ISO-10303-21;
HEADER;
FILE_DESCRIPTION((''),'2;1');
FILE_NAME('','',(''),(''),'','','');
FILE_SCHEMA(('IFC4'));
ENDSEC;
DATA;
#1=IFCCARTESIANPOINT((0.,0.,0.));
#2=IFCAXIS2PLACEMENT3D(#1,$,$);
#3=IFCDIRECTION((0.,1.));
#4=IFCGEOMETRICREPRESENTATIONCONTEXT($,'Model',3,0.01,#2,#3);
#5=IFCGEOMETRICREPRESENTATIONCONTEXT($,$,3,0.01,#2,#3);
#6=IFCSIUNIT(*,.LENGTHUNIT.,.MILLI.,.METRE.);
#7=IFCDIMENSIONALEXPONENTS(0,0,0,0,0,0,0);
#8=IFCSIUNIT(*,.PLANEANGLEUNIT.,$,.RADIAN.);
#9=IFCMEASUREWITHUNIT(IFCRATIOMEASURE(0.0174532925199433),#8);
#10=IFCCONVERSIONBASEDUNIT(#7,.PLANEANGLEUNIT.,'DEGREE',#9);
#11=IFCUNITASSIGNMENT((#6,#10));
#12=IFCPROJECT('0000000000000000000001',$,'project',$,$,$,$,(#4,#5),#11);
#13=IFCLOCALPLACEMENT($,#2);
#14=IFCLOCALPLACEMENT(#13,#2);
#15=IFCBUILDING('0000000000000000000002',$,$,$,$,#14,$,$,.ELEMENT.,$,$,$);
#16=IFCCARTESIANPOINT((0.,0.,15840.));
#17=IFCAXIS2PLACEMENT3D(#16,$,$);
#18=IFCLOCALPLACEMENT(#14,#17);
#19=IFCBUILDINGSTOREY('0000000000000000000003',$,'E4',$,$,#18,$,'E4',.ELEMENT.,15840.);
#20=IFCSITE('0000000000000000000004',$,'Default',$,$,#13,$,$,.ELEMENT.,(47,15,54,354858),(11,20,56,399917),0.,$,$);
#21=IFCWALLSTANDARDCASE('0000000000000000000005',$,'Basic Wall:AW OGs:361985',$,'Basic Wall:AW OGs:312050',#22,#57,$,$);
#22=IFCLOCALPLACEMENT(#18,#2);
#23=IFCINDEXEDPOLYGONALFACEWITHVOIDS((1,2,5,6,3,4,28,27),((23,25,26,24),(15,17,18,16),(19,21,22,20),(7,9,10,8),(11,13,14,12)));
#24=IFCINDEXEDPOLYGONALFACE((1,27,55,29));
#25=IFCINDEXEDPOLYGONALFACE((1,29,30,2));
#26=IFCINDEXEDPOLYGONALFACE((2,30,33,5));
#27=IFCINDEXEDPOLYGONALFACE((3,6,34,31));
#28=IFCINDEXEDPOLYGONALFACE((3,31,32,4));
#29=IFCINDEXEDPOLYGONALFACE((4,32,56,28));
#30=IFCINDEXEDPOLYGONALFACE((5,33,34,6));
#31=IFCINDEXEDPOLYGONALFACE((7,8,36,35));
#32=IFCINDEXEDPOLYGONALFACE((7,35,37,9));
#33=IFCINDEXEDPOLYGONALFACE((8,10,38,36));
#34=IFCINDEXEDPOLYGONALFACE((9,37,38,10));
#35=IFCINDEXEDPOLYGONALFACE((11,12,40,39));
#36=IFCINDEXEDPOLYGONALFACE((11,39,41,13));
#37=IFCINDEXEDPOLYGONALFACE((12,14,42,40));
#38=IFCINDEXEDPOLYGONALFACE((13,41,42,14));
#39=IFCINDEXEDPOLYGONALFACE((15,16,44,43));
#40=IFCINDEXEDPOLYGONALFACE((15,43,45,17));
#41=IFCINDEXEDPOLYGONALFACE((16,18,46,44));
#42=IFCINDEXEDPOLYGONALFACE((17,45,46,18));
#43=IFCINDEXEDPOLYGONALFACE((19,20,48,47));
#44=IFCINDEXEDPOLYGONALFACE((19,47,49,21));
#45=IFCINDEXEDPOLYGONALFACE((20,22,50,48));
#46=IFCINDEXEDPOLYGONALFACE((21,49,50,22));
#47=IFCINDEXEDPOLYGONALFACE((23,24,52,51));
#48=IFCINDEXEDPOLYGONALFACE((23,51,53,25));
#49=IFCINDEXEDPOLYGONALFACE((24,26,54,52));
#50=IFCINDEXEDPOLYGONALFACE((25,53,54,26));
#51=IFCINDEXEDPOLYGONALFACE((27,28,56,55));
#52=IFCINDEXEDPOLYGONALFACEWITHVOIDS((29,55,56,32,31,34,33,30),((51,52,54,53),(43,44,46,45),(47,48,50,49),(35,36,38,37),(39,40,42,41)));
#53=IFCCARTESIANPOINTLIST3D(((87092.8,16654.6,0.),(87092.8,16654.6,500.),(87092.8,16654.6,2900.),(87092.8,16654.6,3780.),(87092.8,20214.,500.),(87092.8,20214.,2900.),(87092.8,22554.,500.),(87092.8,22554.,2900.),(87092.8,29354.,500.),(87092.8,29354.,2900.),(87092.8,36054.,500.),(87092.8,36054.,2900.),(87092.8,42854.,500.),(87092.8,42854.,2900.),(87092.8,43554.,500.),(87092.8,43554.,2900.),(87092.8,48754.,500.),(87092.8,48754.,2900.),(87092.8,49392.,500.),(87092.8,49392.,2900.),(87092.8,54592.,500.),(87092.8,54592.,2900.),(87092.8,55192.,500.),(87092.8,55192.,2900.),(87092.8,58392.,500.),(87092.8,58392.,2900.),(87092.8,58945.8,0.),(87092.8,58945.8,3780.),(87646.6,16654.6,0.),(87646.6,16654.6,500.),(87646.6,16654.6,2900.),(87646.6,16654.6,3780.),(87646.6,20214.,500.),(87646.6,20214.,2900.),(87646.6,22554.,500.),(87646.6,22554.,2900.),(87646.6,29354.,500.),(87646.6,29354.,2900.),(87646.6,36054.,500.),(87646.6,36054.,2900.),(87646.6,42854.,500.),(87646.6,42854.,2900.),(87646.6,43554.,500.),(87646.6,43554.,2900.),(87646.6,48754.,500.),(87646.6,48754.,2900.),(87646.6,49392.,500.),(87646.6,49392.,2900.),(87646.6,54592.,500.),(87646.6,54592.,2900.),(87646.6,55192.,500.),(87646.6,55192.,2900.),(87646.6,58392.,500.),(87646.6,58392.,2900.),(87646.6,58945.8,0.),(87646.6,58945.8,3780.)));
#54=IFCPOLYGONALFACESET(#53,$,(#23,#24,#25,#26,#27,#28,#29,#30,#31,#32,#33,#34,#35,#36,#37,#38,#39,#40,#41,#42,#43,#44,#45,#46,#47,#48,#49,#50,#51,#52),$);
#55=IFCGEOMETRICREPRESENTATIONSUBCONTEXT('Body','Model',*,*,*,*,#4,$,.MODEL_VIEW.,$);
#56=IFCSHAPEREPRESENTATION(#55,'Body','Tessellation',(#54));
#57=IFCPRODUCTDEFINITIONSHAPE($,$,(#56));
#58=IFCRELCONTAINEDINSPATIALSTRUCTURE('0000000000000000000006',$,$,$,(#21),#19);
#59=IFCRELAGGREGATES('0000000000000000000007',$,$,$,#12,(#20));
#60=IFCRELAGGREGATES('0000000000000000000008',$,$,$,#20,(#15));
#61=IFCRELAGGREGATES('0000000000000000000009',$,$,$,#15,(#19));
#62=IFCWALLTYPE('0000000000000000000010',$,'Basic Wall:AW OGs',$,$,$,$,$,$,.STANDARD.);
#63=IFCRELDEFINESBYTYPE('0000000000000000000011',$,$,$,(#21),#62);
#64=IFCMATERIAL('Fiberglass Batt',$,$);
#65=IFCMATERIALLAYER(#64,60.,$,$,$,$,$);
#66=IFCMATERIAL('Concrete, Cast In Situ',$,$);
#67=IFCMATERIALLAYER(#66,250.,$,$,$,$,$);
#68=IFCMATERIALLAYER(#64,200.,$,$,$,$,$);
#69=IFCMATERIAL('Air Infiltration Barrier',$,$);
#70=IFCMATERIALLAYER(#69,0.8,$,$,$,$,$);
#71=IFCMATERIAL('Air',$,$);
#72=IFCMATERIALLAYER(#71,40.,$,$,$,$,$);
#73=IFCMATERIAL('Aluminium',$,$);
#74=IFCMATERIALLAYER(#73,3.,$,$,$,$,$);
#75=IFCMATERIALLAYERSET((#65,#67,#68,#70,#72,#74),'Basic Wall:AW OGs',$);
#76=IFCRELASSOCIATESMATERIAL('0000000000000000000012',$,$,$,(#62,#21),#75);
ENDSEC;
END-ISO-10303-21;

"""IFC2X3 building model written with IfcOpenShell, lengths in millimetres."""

from ifc_helpers import new_model, entity, si_unit, converted_unit, direction, frame, frame_2d, origin, place, context, subcontext, project, spatial, rectangle, extrude, material, layer, layer_set, layer_usage, type_object, element, save


model = new_model("IFC2X3")

# Units and contexts
model_context = context("Model", 3, precision=0.01, world=origin(), true_north=direction((0.0, 1.0)))
context_of_model = context(None, 3, precision=0.01, world=origin(), true_north=direction((0.0, 1.0)))
body_context = subcontext(model_context, "Body", "Model", "MODEL_VIEW")
ifc_project = project(units=[si_unit("LENGTHUNIT", "METRE", prefix="MILLI"), converted_unit("PLANEANGLEUNIT", "DEGREE", entity("IfcRatioMeasure", 0.0174532925199433), si_unit("PLANEANGLEUNIT", "RADIAN"), dimensions=[0, 0, 0, 0, 0, 0, 0])], contexts=[model_context, context_of_model])

# Site, building, storey
site_placement = place(None, origin())
site = spatial("IfcSite", under=ifc_project, at=site_placement, Name="Default", CompositionType="ELEMENT", RefLatitude=(47, 15, 54, 354858), RefLongitude=(11, 20, 56, 399917), RefElevation=0.0)
building_placement = place(site_placement, origin())
building = spatial("IfcBuilding", under=site, at=building_placement, CompositionType="ELEMENT")
storey_placement = place(building_placement, frame((0.0, 0.0, 15840.0)))
storey = spatial("IfcBuildingStorey", under=building, at=storey_placement, Name="E4", LongName="E4", CompositionType="ELEMENT", Elevation=15840.0)

# Shared definitions
ifc_material_1 = material(Name="Concrete, Cast In Situ")

# Shared definitions
ifc_material_2 = material(Name="Fiberglass Batt")
ifc_layer_1 = layer(ifc_material_2, 60.0)
ifc_layer_2 = layer(ifc_material_1, 250.0)
ifc_layer_3 = layer(ifc_material_2, 200.0)
ifc_material_3 = material(Name="Air Infiltration Barrier")
ifc_layer_4 = layer(ifc_material_3, 0.8)
ifc_material_4 = material(Name="Air")
ifc_layer_5 = layer(ifc_material_4, 40.0)
ifc_material_5 = material(Name="Aluminium")
ifc_layer_6 = layer(ifc_material_5, 3.0)
ifc_layer_set_1 = layer_set([ifc_layer_1, ifc_layer_2, ifc_layer_3, ifc_layer_4, ifc_layer_5, ifc_layer_6], Name="Basic Wall:AW OGs")
wall_type_1 = type_object("IfcWallType", Name="Basic Wall:AW OGs", PredefinedType="STANDARD", material=ifc_layer_set_1)

# Wall, openings
ifc_layer_usage_1 = layer_usage(ifc_layer_set_1, "AXIS2", "NEGATIVE", 276.9)
wall_1_placement = place(storey_placement, frame((87369.7, 16654.6, 0.0), z_axis=(0.0, 0.0, 1.0), x_axis=(0.0, 1.0, 0.0)))
wall_1 = element("IfcWallStandardCase", 1, at=wall_1_placement, inside=storey, type_object=wall_type_1, material=ifc_layer_usage_1, Name="Basic Wall:AW OGs:361985", ObjectType="Basic Wall:AW OGs:312050", context=body_context, shape_type="SweptSolid", body=[
    extrude(rectangle(XDim=42291.2, YDim=553.8, at=frame_2d((21145.6, 0.0), x_axis=(-1.0, 0.0))), origin(), (0.0, 0.0, 1.0), 3780.0),
])
opening_1_placement = place(wall_1_placement, frame((3559.4, 276.9, 500.0)))
element("IfcOpeningElement", 2, at=opening_1_placement, cuts=wall_1, ObjectType="Opening", context=body_context, shape_type="SweptSolid", body=[
    extrude(rectangle(XDim=2400.0, YDim=6800.0, at=frame_2d((1200.0, 3400.0), x_axis=(-1.0, 0.0))), frame((0.0, 0.0, 0.0), z_axis=(0.0, -1.0, 0.0), x_axis=(0.0, 0.0, 1.0)), (0.0, 0.0, 1.0), 553.8),
])
opening_2_placement = place(wall_1_placement, frame((12699.4, 276.9, 500.0)))
element("IfcOpeningElement", 3, at=opening_2_placement, cuts=wall_1, ObjectType="Opening", context=body_context, shape_type="SweptSolid", body=[
    extrude(rectangle(XDim=2400.0, YDim=6800.0, at=frame_2d((1200.0, 3400.0), x_axis=(-1.0, 0.0))), frame((0.0, 0.0, 0.0), z_axis=(0.0, -1.0, 0.0), x_axis=(0.0, 0.0, 1.0)), (0.0, 0.0, 1.0), 553.8),
])
opening_3_placement = place(wall_1_placement, frame((26199.4, 276.9, 500.0)))
element("IfcOpeningElement", 4, at=opening_3_placement, cuts=wall_1, ObjectType="Opening", context=body_context, shape_type="SweptSolid", body=[
    extrude(rectangle(XDim=2400.0, YDim=6800.0, at=frame_2d((1200.0, 3400.0), x_axis=(-1.0, 0.0))), frame((0.0, 0.0, 0.0), z_axis=(0.0, -1.0, 0.0), x_axis=(0.0, 0.0, 1.0)), (0.0, 0.0, 1.0), 553.8),
])
opening_4_placement = place(wall_1_placement, frame((32099.4, 276.9, 500.0)))
element("IfcOpeningElement", 5, at=opening_4_placement, cuts=wall_1, ObjectType="Opening", context=body_context, shape_type="SweptSolid", body=[
    extrude(rectangle(XDim=2400.0, YDim=5200.0, at=frame_2d((1200.0, 2600.0), x_axis=(-1.0, 0.0))), frame((0.0, 0.0, 0.0), z_axis=(0.0, -1.0, 0.0), x_axis=(0.0, 0.0, 1.0)), (0.0, 0.0, 1.0), 553.8),
])
opening_5_placement = place(wall_1_placement, frame((37937.4, 276.9, 500.0)))
element("IfcOpeningElement", 6, at=opening_5_placement, cuts=wall_1, ObjectType="Opening", context=body_context, shape_type="SweptSolid", body=[
    extrude(rectangle(XDim=2400.0, YDim=5200.0, at=frame_2d((1200.0, 2600.0), x_axis=(-1.0, 0.0))), frame((0.0, 0.0, 0.0), z_axis=(0.0, -1.0, 0.0), x_axis=(0.0, 0.0, 1.0)), (0.0, 0.0, 1.0), 553.8),
])
opening_6_placement = place(wall_1_placement, frame((41737.4, 276.9, 500.0)))
element("IfcOpeningElement", 7, at=opening_6_placement, cuts=wall_1, ObjectType="Opening", context=body_context, shape_type="SweptSolid", body=[
    extrude(rectangle(XDim=2400.0, YDim=3200.0, at=frame_2d((1200.0, 1600.0), x_axis=(-1.0, 0.0))), frame((0.0, 0.0, 0.0), z_axis=(0.0, -1.0, 0.0), x_axis=(0.0, 0.0, 1.0)), (0.0, 0.0, 1.0), 553.8),
])

save(model, "model.ifc")
